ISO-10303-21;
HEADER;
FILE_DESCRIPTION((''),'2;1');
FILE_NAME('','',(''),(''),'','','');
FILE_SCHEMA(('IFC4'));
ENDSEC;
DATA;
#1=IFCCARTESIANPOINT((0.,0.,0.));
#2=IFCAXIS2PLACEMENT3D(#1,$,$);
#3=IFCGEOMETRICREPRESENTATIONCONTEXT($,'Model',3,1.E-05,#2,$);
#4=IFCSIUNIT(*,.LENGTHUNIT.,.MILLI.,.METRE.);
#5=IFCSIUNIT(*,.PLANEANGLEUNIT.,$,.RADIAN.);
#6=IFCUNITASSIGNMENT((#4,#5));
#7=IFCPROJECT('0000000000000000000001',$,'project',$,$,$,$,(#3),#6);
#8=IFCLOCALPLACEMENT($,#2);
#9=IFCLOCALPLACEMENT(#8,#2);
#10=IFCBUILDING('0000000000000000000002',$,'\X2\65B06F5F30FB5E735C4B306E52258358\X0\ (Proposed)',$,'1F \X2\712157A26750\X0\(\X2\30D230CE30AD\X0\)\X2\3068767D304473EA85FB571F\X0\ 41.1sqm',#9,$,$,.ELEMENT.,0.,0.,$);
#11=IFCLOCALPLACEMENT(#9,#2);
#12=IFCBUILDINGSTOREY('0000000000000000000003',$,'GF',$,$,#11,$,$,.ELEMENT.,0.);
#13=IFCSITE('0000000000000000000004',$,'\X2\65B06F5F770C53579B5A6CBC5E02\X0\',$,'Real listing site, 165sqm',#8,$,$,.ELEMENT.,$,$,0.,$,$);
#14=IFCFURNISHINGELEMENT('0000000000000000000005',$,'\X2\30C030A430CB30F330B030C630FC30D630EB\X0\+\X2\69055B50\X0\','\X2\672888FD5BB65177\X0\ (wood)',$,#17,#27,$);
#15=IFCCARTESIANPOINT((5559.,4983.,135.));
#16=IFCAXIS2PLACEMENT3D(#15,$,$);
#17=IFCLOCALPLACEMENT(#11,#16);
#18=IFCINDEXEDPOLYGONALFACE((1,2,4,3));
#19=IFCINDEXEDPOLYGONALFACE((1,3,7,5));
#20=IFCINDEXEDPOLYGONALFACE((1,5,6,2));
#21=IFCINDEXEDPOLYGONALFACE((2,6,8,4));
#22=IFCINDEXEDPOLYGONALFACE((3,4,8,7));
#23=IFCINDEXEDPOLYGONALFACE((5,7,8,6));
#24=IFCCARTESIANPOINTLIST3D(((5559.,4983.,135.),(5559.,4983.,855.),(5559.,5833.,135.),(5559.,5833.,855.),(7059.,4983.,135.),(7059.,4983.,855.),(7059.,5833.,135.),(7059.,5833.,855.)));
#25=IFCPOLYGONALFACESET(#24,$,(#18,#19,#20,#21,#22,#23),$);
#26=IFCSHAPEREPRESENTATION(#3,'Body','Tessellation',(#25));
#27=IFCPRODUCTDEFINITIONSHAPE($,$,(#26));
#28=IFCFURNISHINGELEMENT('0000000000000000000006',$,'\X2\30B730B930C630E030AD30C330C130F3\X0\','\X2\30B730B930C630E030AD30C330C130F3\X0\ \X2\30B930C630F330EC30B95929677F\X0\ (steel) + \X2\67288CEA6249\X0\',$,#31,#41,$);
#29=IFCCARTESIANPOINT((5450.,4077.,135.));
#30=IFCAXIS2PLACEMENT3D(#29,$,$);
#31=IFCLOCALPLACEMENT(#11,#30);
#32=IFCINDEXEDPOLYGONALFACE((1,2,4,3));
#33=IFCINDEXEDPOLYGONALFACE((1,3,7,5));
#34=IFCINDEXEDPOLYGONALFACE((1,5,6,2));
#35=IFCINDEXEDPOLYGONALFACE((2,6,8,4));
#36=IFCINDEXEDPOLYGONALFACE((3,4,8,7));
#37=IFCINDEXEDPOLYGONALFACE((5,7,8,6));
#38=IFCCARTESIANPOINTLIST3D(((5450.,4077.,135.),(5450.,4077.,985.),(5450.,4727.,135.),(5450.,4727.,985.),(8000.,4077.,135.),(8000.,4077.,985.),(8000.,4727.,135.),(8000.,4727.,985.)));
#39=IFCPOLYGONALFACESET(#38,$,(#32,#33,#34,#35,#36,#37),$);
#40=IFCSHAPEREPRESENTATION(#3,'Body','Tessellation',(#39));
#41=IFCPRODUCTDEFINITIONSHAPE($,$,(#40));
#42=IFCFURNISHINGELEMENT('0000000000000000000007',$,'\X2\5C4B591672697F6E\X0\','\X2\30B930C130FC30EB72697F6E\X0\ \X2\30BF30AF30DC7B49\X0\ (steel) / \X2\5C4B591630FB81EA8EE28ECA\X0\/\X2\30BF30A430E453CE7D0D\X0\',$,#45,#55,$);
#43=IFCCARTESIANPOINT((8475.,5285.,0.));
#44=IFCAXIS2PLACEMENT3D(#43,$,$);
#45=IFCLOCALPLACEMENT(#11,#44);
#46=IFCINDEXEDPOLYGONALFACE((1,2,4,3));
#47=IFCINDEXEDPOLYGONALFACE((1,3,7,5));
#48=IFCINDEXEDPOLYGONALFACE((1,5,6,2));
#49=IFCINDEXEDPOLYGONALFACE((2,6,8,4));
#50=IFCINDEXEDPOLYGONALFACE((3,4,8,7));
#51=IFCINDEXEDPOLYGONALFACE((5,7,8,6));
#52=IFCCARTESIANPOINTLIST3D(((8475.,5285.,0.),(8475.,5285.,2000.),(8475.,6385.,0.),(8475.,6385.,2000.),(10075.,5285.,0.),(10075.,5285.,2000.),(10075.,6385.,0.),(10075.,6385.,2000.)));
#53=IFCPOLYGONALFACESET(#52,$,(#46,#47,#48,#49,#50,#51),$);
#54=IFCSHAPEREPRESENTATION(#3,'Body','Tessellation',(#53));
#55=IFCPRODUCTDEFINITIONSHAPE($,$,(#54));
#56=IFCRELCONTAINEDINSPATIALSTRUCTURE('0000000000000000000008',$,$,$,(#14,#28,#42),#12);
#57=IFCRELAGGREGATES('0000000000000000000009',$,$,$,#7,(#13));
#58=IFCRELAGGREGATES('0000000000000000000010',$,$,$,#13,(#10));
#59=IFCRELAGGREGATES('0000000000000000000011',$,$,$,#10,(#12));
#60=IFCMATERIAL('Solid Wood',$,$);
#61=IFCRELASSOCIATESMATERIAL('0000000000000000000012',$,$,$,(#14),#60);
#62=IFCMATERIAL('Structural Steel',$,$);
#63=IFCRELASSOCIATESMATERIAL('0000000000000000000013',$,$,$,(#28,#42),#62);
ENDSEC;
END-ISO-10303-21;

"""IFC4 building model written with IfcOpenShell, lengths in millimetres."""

from ifc_helpers import new_model, si_unit, frame, frame_2d, origin, place, context, project, spatial, rectangle, extrude, material, element, save


model = new_model("IFC4")

# Units and contexts
model_context = context("Model", 3, precision=1e-05, world=origin())
ifc_project = project(units=[si_unit("LENGTHUNIT", "METRE", prefix="MILLI"), si_unit("PLANEANGLEUNIT", "RADIAN")], contexts=[model_context])

# Site, building, storey
site_placement = place(None, origin())
site = spatial("IfcSite", under=ifc_project, at=site_placement, Name="新潟県南魚沼市", ObjectType="Real listing site, 165sqm", CompositionType="ELEMENT", RefElevation=0.0)
building_placement = place(site_placement, origin())
building = spatial("IfcBuilding", under=site, at=building_placement, Name="新潟・平屋の別荘 (Proposed)", ObjectType="1F 無垢材(ヒノキ)と白い珪藻土 41.1sqm", CompositionType="ELEMENT", ElevationOfRefHeight=0.0, ElevationOfTerrain=0.0)
storey_placement = place(building_placement, origin())
storey = spatial("IfcBuildingStorey", under=building, at=storey_placement, Name="GF", CompositionType="ELEMENT", Elevation=0.0)

# Shared definitions
ifc_material_1 = material(Name="Solid Wood")

# Shared definitions
ifc_material_2 = material(Name="Structural Steel")

# Furnishing elements
furnishing_1_placement = place(storey_placement, frame((5559.0, 4983.0, 135.0)))
element("IfcFurnishingElement", 1, at=furnishing_1_placement, inside=storey, material=ifc_material_1, Name="ダイニングテーブル+椅子", Description="木製家具 (wood)", context=model_context, shape_type="SweptSolid", body=[
    extrude(rectangle(XDim=1500.0, YDim=850.0, at=frame_2d((750.0, 425.0))), frame((5559.0, 4983.0, 135.0)), (0.0, 0.0, 1.0), 720.0),
])
furnishing_2_placement = place(storey_placement, frame((5450.0, 4077.0, 135.0)))
element("IfcFurnishingElement", 2, at=furnishing_2_placement, inside=storey, material=ifc_material_2, Name="システムキッチン", Description="システムキッチン ステンレス天板 (steel) + 木質扉", context=model_context, shape_type="SweptSolid", body=[
    extrude(rectangle(XDim=2550.0, YDim=650.0, at=frame_2d((1275.0, 325.0))), frame((5450.0, 4077.0, 135.0)), (0.0, 0.0, 1.0), 850.0),
])
furnishing_3_placement = place(storey_placement, frame((8475.0, 5285.0, 0.0)))
element("IfcFurnishingElement", 3, at=furnishing_3_placement, inside=storey, material=ifc_material_2, Name="屋外物置", Description="スチール物置 タクボ等 (steel) / 屋外・自転車/タイヤ収納", context=model_context, shape_type="SweptSolid", body=[
    extrude(rectangle(XDim=1600.0, YDim=1100.0, at=frame_2d((800.0, 550.0))), frame((8475.0, 5285.0, 0.0)), (0.0, 0.0, 1.0), 2000.0),
])

save(model, "model.ifc")
